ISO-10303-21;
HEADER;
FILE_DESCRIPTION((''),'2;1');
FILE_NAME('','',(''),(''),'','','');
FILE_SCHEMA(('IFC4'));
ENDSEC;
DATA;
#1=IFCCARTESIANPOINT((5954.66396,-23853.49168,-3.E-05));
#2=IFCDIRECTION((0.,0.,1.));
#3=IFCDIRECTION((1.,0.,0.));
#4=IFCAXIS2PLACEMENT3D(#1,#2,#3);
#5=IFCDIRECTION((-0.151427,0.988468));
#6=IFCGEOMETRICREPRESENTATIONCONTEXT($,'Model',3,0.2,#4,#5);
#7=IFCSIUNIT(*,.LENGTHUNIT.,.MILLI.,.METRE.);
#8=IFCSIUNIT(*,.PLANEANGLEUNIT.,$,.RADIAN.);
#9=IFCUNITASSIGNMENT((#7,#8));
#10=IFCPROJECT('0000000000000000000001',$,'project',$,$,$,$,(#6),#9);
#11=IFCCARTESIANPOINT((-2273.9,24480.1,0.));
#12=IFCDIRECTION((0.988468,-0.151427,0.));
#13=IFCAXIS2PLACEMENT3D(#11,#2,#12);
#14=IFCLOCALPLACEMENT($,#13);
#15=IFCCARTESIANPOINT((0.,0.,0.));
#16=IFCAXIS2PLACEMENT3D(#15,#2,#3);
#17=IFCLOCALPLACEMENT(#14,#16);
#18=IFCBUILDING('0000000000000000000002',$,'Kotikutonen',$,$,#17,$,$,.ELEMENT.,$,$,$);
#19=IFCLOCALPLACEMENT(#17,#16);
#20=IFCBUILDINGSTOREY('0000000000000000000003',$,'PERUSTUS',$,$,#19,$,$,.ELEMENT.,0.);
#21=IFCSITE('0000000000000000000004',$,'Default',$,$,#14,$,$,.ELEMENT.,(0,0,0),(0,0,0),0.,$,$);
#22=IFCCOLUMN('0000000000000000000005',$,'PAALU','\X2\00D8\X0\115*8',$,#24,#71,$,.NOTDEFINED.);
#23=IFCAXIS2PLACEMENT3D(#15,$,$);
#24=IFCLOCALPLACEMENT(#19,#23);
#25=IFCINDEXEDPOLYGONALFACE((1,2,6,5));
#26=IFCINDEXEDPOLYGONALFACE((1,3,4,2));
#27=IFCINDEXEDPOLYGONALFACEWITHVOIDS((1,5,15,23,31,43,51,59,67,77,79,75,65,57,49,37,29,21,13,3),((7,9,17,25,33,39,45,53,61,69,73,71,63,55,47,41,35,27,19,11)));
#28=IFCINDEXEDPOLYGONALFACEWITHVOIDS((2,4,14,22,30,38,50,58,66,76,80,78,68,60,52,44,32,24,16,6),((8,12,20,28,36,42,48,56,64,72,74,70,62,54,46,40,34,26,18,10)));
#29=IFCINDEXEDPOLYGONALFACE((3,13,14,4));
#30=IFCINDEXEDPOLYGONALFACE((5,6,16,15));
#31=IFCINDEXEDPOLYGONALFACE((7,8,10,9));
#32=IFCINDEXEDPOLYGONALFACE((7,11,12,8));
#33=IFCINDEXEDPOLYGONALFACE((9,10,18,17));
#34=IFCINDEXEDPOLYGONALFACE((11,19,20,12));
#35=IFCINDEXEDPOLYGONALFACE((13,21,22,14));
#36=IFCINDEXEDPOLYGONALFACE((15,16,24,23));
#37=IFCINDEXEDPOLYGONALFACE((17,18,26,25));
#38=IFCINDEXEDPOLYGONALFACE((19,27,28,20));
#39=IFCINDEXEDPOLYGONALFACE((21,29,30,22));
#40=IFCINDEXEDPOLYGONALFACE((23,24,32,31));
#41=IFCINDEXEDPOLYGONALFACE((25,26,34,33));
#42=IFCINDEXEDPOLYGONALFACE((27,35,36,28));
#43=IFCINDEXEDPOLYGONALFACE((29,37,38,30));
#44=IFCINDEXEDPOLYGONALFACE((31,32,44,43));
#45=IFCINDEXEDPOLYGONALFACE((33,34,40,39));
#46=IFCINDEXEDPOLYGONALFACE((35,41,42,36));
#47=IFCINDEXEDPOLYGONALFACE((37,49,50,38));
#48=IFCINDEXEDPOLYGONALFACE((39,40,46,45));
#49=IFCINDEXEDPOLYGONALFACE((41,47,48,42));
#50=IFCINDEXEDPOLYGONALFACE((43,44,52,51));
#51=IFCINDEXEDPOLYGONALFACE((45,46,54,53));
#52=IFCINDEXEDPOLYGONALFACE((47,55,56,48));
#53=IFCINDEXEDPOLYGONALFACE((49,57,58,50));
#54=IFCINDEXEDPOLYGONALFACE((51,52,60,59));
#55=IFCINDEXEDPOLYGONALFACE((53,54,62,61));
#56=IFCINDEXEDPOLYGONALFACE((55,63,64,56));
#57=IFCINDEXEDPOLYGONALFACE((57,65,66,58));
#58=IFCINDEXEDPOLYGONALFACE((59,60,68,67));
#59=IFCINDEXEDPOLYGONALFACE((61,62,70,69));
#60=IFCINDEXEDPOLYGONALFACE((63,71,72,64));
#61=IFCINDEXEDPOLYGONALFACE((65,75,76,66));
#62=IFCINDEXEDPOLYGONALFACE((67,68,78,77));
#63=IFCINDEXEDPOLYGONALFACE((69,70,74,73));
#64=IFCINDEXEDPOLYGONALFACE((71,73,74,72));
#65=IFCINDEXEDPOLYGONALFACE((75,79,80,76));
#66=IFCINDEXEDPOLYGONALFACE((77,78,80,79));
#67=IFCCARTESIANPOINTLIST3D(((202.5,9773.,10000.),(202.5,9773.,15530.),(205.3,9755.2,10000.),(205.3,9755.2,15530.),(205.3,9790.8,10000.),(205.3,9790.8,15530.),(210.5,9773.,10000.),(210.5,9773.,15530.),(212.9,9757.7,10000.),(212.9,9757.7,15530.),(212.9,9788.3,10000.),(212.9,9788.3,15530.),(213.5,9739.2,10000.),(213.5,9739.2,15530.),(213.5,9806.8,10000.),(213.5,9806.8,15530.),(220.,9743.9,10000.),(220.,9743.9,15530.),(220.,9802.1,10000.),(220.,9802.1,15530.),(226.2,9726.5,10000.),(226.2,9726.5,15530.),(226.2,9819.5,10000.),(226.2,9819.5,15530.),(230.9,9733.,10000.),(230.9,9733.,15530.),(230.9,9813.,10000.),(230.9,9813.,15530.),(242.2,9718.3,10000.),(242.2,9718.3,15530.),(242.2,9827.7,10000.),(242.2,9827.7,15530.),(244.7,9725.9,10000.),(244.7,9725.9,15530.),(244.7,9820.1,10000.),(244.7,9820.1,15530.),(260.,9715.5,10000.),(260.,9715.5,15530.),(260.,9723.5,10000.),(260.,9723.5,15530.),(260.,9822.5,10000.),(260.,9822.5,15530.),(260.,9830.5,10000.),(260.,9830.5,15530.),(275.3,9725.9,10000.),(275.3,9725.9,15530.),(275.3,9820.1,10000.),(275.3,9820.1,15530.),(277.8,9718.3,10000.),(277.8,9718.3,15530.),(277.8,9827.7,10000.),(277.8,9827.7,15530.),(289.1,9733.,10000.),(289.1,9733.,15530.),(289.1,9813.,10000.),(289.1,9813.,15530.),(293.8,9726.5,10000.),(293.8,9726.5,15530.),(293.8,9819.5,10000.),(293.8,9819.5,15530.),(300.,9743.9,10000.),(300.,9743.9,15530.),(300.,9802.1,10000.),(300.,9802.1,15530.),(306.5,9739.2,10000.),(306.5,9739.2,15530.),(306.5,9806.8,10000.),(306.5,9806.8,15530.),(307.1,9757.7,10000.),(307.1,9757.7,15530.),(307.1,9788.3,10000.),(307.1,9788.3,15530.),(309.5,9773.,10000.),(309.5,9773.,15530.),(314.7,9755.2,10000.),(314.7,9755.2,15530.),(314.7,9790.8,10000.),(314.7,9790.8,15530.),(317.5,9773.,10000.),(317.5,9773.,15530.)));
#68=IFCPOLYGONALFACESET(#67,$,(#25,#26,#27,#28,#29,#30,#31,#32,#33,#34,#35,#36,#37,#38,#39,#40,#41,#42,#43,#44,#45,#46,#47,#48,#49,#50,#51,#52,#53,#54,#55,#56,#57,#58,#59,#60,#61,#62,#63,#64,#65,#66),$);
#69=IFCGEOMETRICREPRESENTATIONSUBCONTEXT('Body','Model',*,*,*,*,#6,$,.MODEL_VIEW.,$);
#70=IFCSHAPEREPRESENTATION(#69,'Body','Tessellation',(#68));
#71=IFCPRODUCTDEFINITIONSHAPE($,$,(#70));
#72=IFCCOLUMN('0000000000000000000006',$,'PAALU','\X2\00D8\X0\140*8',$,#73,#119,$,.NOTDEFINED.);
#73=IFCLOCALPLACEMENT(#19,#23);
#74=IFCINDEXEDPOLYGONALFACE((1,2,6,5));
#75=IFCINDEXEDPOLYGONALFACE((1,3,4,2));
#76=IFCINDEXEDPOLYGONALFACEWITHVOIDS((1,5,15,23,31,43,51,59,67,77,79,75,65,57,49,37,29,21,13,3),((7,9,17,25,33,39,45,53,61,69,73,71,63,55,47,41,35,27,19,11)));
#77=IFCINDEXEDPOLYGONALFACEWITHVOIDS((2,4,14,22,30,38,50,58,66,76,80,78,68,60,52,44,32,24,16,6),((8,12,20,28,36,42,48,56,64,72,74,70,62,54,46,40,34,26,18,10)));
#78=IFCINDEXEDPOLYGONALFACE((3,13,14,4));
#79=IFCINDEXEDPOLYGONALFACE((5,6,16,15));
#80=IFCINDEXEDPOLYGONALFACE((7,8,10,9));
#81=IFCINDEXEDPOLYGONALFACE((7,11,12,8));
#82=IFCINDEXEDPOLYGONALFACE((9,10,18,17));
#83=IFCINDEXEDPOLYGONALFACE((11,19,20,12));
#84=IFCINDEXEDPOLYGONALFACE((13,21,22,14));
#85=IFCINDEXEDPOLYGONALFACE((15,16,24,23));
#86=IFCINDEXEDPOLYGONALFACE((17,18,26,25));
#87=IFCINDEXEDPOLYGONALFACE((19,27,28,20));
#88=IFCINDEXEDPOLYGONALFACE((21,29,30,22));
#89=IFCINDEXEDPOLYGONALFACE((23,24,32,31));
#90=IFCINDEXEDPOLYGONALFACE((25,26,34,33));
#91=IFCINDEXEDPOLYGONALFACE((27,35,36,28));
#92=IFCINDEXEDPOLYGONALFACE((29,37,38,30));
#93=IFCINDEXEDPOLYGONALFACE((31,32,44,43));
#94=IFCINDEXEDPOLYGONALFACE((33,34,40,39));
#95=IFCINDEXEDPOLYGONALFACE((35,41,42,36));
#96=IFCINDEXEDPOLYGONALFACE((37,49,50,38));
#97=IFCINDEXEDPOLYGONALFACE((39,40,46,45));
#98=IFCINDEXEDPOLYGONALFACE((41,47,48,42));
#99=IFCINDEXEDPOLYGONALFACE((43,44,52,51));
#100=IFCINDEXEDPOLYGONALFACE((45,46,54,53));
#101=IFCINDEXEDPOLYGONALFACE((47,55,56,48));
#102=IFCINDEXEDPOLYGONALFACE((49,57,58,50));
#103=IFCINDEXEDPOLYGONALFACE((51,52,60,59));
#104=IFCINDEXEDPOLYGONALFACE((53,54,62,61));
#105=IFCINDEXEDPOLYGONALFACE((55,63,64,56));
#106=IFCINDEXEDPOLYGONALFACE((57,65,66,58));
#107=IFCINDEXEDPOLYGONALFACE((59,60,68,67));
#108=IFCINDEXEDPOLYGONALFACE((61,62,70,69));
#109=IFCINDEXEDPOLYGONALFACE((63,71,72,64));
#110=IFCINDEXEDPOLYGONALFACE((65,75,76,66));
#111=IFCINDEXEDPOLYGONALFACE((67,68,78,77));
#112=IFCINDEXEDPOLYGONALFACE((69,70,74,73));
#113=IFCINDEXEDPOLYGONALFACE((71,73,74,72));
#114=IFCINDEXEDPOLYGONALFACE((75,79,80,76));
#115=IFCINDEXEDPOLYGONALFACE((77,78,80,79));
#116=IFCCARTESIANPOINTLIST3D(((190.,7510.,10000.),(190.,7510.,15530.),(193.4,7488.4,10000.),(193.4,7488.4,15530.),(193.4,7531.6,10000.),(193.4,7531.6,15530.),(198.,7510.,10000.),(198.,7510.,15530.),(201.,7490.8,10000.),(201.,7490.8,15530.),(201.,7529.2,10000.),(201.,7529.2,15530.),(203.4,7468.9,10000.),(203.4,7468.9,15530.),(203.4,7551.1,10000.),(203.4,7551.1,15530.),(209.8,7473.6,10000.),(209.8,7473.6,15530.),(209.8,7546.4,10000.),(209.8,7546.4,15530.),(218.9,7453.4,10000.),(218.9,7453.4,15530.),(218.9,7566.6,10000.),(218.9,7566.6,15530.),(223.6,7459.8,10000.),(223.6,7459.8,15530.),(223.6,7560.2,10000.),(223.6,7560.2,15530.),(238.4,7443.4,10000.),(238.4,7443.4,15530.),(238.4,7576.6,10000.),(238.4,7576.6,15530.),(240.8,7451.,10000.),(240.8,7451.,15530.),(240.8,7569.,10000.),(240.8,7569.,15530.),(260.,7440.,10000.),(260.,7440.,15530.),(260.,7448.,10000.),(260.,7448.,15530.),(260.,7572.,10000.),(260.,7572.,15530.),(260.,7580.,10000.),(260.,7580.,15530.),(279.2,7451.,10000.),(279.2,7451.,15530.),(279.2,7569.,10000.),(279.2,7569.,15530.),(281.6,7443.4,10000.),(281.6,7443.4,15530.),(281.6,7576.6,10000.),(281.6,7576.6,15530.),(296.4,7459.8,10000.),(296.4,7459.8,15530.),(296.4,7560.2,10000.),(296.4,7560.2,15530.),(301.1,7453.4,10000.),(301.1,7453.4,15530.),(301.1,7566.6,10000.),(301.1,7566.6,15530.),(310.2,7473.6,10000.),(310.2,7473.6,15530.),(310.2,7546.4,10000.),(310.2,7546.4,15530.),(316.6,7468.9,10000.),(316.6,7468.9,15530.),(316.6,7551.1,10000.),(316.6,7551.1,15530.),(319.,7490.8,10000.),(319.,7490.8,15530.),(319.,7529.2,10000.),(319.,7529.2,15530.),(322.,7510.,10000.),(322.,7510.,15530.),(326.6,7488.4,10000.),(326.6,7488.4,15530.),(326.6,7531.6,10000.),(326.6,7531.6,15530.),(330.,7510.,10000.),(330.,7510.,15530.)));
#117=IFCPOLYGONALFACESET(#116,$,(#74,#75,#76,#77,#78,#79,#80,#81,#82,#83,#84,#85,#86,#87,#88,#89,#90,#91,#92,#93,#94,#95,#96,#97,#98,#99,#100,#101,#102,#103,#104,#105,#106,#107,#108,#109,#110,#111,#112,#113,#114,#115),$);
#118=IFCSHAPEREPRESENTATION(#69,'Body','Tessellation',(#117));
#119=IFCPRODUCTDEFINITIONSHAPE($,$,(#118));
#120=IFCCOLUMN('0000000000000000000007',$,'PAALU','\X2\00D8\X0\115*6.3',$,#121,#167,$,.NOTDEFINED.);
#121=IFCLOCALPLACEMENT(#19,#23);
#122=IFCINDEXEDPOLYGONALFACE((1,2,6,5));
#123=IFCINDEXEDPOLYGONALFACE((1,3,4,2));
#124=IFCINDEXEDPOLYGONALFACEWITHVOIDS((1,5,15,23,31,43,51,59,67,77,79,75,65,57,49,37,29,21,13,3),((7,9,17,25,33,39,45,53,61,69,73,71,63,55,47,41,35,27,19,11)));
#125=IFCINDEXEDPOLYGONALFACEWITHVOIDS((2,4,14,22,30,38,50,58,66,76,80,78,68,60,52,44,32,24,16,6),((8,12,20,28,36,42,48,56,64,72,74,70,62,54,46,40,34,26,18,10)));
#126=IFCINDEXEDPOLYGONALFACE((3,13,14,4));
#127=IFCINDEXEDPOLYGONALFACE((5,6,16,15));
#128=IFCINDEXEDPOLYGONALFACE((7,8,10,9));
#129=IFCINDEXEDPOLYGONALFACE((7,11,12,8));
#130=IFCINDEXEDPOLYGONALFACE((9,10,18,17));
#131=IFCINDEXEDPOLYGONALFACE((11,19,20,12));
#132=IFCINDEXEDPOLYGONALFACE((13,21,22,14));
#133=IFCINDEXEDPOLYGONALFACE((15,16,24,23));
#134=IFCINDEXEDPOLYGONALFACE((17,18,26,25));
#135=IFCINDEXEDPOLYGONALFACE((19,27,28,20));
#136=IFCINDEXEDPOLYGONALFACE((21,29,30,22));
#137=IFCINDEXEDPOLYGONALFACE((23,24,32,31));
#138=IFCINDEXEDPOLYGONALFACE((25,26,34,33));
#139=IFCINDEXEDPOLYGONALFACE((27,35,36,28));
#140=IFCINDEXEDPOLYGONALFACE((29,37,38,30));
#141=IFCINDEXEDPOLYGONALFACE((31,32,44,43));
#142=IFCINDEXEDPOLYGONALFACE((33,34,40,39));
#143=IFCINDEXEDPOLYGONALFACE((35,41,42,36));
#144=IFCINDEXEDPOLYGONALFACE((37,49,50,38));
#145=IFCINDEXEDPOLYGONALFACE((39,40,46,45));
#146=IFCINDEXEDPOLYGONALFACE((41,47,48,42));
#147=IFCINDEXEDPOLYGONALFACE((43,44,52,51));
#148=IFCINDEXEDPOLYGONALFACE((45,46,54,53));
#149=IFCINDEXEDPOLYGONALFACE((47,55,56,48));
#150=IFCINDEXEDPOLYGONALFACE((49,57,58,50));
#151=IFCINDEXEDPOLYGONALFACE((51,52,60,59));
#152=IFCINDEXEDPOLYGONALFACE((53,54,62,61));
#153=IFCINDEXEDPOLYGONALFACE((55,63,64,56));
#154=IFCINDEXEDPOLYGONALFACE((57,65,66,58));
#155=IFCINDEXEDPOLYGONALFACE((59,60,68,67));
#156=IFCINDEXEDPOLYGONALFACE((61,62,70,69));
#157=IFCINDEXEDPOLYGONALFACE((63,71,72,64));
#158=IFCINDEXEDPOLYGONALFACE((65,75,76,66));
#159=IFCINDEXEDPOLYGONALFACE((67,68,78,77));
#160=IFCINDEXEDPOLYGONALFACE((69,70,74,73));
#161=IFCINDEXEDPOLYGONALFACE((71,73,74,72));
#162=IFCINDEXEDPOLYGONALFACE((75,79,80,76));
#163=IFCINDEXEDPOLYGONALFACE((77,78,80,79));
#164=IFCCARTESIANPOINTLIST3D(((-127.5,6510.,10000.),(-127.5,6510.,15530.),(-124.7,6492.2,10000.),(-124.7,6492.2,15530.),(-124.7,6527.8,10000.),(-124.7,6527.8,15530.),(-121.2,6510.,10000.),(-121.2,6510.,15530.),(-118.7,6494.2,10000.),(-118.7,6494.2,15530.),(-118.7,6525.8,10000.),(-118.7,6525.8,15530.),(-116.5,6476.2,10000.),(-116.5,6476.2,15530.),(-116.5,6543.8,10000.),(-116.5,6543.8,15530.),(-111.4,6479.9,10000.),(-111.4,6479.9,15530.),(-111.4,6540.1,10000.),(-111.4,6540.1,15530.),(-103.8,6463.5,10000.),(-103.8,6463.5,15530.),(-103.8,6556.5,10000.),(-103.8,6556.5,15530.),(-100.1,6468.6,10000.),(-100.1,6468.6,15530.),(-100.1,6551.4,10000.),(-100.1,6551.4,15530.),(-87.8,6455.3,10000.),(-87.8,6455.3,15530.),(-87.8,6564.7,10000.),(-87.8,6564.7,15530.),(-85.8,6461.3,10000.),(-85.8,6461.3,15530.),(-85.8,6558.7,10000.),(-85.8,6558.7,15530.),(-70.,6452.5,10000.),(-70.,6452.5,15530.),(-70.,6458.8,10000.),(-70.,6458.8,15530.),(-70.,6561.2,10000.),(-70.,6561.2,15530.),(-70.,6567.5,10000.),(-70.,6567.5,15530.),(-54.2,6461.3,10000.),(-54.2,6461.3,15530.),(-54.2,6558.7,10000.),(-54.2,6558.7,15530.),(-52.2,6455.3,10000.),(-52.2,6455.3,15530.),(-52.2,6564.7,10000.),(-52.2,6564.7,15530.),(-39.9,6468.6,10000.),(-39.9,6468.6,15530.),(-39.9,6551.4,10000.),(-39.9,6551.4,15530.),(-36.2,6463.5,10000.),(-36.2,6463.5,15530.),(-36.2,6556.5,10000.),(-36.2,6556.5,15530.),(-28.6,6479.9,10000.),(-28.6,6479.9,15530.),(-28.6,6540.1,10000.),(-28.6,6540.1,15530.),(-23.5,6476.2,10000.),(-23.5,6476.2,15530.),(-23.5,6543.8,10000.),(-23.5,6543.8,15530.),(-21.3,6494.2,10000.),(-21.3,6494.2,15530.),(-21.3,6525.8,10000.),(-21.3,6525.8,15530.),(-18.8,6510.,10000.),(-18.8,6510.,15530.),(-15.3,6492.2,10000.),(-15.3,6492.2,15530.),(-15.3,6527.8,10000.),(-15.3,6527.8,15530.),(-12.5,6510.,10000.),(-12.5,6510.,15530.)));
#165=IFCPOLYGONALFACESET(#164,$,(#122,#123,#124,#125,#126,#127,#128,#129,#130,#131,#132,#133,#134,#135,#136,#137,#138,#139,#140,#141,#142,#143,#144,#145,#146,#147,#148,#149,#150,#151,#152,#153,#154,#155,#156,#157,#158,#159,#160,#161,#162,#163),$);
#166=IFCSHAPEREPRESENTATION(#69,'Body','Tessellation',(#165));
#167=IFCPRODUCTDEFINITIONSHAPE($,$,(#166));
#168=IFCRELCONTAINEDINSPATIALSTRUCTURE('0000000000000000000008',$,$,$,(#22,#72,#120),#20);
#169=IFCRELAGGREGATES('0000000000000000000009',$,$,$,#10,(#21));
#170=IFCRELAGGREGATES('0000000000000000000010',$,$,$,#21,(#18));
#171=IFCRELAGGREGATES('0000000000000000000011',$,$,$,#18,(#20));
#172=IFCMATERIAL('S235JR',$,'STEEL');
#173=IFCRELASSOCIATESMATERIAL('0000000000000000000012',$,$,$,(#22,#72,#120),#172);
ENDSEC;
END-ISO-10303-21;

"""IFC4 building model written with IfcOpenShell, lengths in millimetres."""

from ifc_helpers import new_model, si_unit, direction, frame, origin_with_axes, place, context, subcontext, project, spatial, line, indexed_curve, outline, extrude, material, element, save


model = new_model("IFC4")

# Units and contexts
model_context = context("Model", 3, precision=0.2, world=frame((5954.66396, -23853.49168, -3e-05), z_axis=(0.0, 0.0, 1.0), x_axis=(1.0, 0.0, 0.0)), true_north=direction((-0.151427, 0.988468)))
body_context = subcontext(model_context, "Body", "Model", "MODEL_VIEW")
ifc_project = project(units=[si_unit("LENGTHUNIT", "METRE", prefix="MILLI"), si_unit("PLANEANGLEUNIT", "RADIAN")], contexts=[model_context])

# Site, building, storey
site_placement = place(None, frame((-2273.9, 24480.1, 0.0), z_axis=(0.0, 0.0, 1.0), x_axis=(0.988468, -0.151427, 0.0)))
site = spatial("IfcSite", under=ifc_project, at=site_placement, Name="Default", CompositionType="ELEMENT", RefLatitude=(0, 0, 0), RefLongitude=(0, 0, 0), RefElevation=0.0)
building_placement = place(site_placement, origin_with_axes())
building = spatial("IfcBuilding", under=site, at=building_placement, Name="Kotikutonen", CompositionType="ELEMENT")
storey_placement = place(building_placement, origin_with_axes())
storey = spatial("IfcBuildingStorey", under=building, at=storey_placement, Name="PERUSTUS", CompositionType="ELEMENT", Elevation=0.0)

# Columns
ifc_material = material(Name="S235JR", Category="STEEL")
for number, where, z_axis, x_axis, name in (
    (1, (260.0, 9773.0, 10000.0), (-1.0, 0.0, 0.0), (0.0, 0.0, 1.0), "PAALU"),
):
    element("IfcColumn", number, at=place(storey_placement, frame(where, z_axis=z_axis, x_axis=x_axis)), inside=storey, material=ifc_material, Name=name, Description="Ø115*8", PredefinedType="NOTDEFINED", context=body_context, shape_type="SolidModel", body=[
        extrude(outline(indexed_curve([(57.5, 0.0), (54.7, 17.8), (46.5, 33.8), (33.8, 46.5), (17.8, 54.7), (0.0, 57.5), (-17.8, 54.7), (-33.8, 46.5), (-46.5, 33.8), (-54.7, 17.8), (-57.5, 0.0), (-54.7, -17.8), (-46.5, -33.8), (-33.8, -46.5), (-17.8, -54.7), (0.0, -57.5), (17.8, -54.7), (33.8, -46.5), (46.5, -33.8), (54.7, -17.8)], segments=[line(1, 2, 3, 4, 5, 6, 7, 8, 9, 10, 11, 12, 13, 14, 15, 16, 17, 18, 19, 20, 1)]), holes=[indexed_curve([(49.5, 0.0), (47.1, -15.3), (40.0, -29.1), (29.1, -40.0), (15.3, -47.1), (0.0, -49.5), (-15.3, -47.1), (-29.1, -40.0), (-40.0, -29.1), (-47.1, -15.3), (-49.5, 0.0), (-47.1, 15.3), (-40.0, 29.1), (-29.1, 40.0), (-15.3, 47.1), (0.0, 49.5), (15.3, 47.1), (29.1, 40.0), (40.0, 29.1), (47.1, 15.3)], segments=[line(1, 2, 3, 4, 5, 6, 7, 8, 9, 10, 11, 12, 13, 14, 15, 16, 17, 18, 19, 20, 1)])]), frame((0.0, 0.0, 0.0), z_axis=(-1.0, 0.0, 0.0), x_axis=(0.0, 0.0, 1.0)), (0.0, 0.0, -1.0), 5530.0),
    ])
column_placement = place(storey_placement, frame((260.0, 7510.0, 10000.0), z_axis=(-1.0, 0.0, 0.0), x_axis=(0.0, 0.0, 1.0)))
element("IfcColumn", 2, at=column_placement, inside=storey, material=ifc_material, Name="PAALU", Description="Ø140*8", PredefinedType="NOTDEFINED", context=body_context, shape_type="SolidModel", body=[
    extrude(outline(indexed_curve([(70.0, 0.0), (66.6, 21.6), (56.6, 41.1), (41.1, 56.6), (21.6, 66.6), (0.0, 70.0), (-21.6, 66.6), (-41.1, 56.6), (-56.6, 41.1), (-66.6, 21.6), (-70.0, 0.0), (-66.6, -21.6), (-56.6, -41.1), (-41.1, -56.6), (-21.6, -66.6), (0.0, -70.0), (21.6, -66.6), (41.1, -56.6), (56.6, -41.1), (66.6, -21.6)], segments=[line(1, 2, 3, 4, 5, 6, 7, 8, 9, 10, 11, 12, 13, 14, 15, 16, 17, 18, 19, 20, 1)]), holes=[indexed_curve([(62.0, 0.0), (59.0, -19.2), (50.2, -36.4), (36.4, -50.2), (19.2, -59.0), (0.0, -62.0), (-19.2, -59.0), (-36.4, -50.2), (-50.2, -36.4), (-59.0, -19.2), (-62.0, 0.0), (-59.0, 19.2), (-50.2, 36.4), (-36.4, 50.2), (-19.2, 59.0), (0.0, 62.0), (19.2, 59.0), (36.4, 50.2), (50.2, 36.4), (59.0, 19.2)], segments=[line(1, 2, 3, 4, 5, 6, 7, 8, 9, 10, 11, 12, 13, 14, 15, 16, 17, 18, 19, 20, 1)])]), frame((0.0, 0.0, 0.0), z_axis=(-1.0, 0.0, 0.0), x_axis=(0.0, 0.0, 1.0)), (0.0, 0.0, -1.0), 5530.0),
])
for number, where, z_axis, x_axis, name in (
    (3, (-70.0, 6510.0, 10000.0), (-1.0, 0.0, 0.0), (0.0, 0.0, 1.0), "PAALU"),
):
    element("IfcColumn", number, at=place(storey_placement, frame(where, z_axis=z_axis, x_axis=x_axis)), inside=storey, material=ifc_material, Name=name, Description="Ø115*6.3", PredefinedType="NOTDEFINED", context=body_context, shape_type="SolidModel", body=[
        extrude(outline(indexed_curve([(57.5, 0.0), (54.7, 17.8), (46.5, 33.8), (33.8, 46.5), (17.8, 54.7), (0.0, 57.5), (-17.8, 54.7), (-33.8, 46.5), (-46.5, 33.8), (-54.7, 17.8), (-57.5, 0.0), (-54.7, -17.8), (-46.5, -33.8), (-33.8, -46.5), (-17.8, -54.7), (0.0, -57.5), (17.8, -54.7), (33.8, -46.5), (46.5, -33.8), (54.7, -17.8)], segments=[line(1, 2, 3, 4, 5, 6, 7, 8, 9, 10, 11, 12, 13, 14, 15, 16, 17, 18, 19, 20, 1)]), holes=[indexed_curve([(51.2, 0.0), (48.7, -15.8), (41.4, -30.1), (30.1, -41.4), (15.8, -48.7), (0.0, -51.2), (-15.8, -48.7), (-30.1, -41.4), (-41.4, -30.1), (-48.7, -15.8), (-51.2, 0.0), (-48.7, 15.8), (-41.4, 30.1), (-30.1, 41.4), (-15.8, 48.7), (0.0, 51.2), (15.8, 48.7), (30.1, 41.4), (41.4, 30.1), (48.7, 15.8)], segments=[line(1, 2, 3, 4, 5, 6, 7, 8, 9, 10, 11, 12, 13, 14, 15, 16, 17, 18, 19, 20, 1)])]), frame((0.0, 0.0, 0.0), z_axis=(-1.0, 0.0, 0.0), x_axis=(0.0, 0.0, 1.0)), (0.0, 0.0, -1.0), 5530.0),
    ])

save(model, "model.ifc")
